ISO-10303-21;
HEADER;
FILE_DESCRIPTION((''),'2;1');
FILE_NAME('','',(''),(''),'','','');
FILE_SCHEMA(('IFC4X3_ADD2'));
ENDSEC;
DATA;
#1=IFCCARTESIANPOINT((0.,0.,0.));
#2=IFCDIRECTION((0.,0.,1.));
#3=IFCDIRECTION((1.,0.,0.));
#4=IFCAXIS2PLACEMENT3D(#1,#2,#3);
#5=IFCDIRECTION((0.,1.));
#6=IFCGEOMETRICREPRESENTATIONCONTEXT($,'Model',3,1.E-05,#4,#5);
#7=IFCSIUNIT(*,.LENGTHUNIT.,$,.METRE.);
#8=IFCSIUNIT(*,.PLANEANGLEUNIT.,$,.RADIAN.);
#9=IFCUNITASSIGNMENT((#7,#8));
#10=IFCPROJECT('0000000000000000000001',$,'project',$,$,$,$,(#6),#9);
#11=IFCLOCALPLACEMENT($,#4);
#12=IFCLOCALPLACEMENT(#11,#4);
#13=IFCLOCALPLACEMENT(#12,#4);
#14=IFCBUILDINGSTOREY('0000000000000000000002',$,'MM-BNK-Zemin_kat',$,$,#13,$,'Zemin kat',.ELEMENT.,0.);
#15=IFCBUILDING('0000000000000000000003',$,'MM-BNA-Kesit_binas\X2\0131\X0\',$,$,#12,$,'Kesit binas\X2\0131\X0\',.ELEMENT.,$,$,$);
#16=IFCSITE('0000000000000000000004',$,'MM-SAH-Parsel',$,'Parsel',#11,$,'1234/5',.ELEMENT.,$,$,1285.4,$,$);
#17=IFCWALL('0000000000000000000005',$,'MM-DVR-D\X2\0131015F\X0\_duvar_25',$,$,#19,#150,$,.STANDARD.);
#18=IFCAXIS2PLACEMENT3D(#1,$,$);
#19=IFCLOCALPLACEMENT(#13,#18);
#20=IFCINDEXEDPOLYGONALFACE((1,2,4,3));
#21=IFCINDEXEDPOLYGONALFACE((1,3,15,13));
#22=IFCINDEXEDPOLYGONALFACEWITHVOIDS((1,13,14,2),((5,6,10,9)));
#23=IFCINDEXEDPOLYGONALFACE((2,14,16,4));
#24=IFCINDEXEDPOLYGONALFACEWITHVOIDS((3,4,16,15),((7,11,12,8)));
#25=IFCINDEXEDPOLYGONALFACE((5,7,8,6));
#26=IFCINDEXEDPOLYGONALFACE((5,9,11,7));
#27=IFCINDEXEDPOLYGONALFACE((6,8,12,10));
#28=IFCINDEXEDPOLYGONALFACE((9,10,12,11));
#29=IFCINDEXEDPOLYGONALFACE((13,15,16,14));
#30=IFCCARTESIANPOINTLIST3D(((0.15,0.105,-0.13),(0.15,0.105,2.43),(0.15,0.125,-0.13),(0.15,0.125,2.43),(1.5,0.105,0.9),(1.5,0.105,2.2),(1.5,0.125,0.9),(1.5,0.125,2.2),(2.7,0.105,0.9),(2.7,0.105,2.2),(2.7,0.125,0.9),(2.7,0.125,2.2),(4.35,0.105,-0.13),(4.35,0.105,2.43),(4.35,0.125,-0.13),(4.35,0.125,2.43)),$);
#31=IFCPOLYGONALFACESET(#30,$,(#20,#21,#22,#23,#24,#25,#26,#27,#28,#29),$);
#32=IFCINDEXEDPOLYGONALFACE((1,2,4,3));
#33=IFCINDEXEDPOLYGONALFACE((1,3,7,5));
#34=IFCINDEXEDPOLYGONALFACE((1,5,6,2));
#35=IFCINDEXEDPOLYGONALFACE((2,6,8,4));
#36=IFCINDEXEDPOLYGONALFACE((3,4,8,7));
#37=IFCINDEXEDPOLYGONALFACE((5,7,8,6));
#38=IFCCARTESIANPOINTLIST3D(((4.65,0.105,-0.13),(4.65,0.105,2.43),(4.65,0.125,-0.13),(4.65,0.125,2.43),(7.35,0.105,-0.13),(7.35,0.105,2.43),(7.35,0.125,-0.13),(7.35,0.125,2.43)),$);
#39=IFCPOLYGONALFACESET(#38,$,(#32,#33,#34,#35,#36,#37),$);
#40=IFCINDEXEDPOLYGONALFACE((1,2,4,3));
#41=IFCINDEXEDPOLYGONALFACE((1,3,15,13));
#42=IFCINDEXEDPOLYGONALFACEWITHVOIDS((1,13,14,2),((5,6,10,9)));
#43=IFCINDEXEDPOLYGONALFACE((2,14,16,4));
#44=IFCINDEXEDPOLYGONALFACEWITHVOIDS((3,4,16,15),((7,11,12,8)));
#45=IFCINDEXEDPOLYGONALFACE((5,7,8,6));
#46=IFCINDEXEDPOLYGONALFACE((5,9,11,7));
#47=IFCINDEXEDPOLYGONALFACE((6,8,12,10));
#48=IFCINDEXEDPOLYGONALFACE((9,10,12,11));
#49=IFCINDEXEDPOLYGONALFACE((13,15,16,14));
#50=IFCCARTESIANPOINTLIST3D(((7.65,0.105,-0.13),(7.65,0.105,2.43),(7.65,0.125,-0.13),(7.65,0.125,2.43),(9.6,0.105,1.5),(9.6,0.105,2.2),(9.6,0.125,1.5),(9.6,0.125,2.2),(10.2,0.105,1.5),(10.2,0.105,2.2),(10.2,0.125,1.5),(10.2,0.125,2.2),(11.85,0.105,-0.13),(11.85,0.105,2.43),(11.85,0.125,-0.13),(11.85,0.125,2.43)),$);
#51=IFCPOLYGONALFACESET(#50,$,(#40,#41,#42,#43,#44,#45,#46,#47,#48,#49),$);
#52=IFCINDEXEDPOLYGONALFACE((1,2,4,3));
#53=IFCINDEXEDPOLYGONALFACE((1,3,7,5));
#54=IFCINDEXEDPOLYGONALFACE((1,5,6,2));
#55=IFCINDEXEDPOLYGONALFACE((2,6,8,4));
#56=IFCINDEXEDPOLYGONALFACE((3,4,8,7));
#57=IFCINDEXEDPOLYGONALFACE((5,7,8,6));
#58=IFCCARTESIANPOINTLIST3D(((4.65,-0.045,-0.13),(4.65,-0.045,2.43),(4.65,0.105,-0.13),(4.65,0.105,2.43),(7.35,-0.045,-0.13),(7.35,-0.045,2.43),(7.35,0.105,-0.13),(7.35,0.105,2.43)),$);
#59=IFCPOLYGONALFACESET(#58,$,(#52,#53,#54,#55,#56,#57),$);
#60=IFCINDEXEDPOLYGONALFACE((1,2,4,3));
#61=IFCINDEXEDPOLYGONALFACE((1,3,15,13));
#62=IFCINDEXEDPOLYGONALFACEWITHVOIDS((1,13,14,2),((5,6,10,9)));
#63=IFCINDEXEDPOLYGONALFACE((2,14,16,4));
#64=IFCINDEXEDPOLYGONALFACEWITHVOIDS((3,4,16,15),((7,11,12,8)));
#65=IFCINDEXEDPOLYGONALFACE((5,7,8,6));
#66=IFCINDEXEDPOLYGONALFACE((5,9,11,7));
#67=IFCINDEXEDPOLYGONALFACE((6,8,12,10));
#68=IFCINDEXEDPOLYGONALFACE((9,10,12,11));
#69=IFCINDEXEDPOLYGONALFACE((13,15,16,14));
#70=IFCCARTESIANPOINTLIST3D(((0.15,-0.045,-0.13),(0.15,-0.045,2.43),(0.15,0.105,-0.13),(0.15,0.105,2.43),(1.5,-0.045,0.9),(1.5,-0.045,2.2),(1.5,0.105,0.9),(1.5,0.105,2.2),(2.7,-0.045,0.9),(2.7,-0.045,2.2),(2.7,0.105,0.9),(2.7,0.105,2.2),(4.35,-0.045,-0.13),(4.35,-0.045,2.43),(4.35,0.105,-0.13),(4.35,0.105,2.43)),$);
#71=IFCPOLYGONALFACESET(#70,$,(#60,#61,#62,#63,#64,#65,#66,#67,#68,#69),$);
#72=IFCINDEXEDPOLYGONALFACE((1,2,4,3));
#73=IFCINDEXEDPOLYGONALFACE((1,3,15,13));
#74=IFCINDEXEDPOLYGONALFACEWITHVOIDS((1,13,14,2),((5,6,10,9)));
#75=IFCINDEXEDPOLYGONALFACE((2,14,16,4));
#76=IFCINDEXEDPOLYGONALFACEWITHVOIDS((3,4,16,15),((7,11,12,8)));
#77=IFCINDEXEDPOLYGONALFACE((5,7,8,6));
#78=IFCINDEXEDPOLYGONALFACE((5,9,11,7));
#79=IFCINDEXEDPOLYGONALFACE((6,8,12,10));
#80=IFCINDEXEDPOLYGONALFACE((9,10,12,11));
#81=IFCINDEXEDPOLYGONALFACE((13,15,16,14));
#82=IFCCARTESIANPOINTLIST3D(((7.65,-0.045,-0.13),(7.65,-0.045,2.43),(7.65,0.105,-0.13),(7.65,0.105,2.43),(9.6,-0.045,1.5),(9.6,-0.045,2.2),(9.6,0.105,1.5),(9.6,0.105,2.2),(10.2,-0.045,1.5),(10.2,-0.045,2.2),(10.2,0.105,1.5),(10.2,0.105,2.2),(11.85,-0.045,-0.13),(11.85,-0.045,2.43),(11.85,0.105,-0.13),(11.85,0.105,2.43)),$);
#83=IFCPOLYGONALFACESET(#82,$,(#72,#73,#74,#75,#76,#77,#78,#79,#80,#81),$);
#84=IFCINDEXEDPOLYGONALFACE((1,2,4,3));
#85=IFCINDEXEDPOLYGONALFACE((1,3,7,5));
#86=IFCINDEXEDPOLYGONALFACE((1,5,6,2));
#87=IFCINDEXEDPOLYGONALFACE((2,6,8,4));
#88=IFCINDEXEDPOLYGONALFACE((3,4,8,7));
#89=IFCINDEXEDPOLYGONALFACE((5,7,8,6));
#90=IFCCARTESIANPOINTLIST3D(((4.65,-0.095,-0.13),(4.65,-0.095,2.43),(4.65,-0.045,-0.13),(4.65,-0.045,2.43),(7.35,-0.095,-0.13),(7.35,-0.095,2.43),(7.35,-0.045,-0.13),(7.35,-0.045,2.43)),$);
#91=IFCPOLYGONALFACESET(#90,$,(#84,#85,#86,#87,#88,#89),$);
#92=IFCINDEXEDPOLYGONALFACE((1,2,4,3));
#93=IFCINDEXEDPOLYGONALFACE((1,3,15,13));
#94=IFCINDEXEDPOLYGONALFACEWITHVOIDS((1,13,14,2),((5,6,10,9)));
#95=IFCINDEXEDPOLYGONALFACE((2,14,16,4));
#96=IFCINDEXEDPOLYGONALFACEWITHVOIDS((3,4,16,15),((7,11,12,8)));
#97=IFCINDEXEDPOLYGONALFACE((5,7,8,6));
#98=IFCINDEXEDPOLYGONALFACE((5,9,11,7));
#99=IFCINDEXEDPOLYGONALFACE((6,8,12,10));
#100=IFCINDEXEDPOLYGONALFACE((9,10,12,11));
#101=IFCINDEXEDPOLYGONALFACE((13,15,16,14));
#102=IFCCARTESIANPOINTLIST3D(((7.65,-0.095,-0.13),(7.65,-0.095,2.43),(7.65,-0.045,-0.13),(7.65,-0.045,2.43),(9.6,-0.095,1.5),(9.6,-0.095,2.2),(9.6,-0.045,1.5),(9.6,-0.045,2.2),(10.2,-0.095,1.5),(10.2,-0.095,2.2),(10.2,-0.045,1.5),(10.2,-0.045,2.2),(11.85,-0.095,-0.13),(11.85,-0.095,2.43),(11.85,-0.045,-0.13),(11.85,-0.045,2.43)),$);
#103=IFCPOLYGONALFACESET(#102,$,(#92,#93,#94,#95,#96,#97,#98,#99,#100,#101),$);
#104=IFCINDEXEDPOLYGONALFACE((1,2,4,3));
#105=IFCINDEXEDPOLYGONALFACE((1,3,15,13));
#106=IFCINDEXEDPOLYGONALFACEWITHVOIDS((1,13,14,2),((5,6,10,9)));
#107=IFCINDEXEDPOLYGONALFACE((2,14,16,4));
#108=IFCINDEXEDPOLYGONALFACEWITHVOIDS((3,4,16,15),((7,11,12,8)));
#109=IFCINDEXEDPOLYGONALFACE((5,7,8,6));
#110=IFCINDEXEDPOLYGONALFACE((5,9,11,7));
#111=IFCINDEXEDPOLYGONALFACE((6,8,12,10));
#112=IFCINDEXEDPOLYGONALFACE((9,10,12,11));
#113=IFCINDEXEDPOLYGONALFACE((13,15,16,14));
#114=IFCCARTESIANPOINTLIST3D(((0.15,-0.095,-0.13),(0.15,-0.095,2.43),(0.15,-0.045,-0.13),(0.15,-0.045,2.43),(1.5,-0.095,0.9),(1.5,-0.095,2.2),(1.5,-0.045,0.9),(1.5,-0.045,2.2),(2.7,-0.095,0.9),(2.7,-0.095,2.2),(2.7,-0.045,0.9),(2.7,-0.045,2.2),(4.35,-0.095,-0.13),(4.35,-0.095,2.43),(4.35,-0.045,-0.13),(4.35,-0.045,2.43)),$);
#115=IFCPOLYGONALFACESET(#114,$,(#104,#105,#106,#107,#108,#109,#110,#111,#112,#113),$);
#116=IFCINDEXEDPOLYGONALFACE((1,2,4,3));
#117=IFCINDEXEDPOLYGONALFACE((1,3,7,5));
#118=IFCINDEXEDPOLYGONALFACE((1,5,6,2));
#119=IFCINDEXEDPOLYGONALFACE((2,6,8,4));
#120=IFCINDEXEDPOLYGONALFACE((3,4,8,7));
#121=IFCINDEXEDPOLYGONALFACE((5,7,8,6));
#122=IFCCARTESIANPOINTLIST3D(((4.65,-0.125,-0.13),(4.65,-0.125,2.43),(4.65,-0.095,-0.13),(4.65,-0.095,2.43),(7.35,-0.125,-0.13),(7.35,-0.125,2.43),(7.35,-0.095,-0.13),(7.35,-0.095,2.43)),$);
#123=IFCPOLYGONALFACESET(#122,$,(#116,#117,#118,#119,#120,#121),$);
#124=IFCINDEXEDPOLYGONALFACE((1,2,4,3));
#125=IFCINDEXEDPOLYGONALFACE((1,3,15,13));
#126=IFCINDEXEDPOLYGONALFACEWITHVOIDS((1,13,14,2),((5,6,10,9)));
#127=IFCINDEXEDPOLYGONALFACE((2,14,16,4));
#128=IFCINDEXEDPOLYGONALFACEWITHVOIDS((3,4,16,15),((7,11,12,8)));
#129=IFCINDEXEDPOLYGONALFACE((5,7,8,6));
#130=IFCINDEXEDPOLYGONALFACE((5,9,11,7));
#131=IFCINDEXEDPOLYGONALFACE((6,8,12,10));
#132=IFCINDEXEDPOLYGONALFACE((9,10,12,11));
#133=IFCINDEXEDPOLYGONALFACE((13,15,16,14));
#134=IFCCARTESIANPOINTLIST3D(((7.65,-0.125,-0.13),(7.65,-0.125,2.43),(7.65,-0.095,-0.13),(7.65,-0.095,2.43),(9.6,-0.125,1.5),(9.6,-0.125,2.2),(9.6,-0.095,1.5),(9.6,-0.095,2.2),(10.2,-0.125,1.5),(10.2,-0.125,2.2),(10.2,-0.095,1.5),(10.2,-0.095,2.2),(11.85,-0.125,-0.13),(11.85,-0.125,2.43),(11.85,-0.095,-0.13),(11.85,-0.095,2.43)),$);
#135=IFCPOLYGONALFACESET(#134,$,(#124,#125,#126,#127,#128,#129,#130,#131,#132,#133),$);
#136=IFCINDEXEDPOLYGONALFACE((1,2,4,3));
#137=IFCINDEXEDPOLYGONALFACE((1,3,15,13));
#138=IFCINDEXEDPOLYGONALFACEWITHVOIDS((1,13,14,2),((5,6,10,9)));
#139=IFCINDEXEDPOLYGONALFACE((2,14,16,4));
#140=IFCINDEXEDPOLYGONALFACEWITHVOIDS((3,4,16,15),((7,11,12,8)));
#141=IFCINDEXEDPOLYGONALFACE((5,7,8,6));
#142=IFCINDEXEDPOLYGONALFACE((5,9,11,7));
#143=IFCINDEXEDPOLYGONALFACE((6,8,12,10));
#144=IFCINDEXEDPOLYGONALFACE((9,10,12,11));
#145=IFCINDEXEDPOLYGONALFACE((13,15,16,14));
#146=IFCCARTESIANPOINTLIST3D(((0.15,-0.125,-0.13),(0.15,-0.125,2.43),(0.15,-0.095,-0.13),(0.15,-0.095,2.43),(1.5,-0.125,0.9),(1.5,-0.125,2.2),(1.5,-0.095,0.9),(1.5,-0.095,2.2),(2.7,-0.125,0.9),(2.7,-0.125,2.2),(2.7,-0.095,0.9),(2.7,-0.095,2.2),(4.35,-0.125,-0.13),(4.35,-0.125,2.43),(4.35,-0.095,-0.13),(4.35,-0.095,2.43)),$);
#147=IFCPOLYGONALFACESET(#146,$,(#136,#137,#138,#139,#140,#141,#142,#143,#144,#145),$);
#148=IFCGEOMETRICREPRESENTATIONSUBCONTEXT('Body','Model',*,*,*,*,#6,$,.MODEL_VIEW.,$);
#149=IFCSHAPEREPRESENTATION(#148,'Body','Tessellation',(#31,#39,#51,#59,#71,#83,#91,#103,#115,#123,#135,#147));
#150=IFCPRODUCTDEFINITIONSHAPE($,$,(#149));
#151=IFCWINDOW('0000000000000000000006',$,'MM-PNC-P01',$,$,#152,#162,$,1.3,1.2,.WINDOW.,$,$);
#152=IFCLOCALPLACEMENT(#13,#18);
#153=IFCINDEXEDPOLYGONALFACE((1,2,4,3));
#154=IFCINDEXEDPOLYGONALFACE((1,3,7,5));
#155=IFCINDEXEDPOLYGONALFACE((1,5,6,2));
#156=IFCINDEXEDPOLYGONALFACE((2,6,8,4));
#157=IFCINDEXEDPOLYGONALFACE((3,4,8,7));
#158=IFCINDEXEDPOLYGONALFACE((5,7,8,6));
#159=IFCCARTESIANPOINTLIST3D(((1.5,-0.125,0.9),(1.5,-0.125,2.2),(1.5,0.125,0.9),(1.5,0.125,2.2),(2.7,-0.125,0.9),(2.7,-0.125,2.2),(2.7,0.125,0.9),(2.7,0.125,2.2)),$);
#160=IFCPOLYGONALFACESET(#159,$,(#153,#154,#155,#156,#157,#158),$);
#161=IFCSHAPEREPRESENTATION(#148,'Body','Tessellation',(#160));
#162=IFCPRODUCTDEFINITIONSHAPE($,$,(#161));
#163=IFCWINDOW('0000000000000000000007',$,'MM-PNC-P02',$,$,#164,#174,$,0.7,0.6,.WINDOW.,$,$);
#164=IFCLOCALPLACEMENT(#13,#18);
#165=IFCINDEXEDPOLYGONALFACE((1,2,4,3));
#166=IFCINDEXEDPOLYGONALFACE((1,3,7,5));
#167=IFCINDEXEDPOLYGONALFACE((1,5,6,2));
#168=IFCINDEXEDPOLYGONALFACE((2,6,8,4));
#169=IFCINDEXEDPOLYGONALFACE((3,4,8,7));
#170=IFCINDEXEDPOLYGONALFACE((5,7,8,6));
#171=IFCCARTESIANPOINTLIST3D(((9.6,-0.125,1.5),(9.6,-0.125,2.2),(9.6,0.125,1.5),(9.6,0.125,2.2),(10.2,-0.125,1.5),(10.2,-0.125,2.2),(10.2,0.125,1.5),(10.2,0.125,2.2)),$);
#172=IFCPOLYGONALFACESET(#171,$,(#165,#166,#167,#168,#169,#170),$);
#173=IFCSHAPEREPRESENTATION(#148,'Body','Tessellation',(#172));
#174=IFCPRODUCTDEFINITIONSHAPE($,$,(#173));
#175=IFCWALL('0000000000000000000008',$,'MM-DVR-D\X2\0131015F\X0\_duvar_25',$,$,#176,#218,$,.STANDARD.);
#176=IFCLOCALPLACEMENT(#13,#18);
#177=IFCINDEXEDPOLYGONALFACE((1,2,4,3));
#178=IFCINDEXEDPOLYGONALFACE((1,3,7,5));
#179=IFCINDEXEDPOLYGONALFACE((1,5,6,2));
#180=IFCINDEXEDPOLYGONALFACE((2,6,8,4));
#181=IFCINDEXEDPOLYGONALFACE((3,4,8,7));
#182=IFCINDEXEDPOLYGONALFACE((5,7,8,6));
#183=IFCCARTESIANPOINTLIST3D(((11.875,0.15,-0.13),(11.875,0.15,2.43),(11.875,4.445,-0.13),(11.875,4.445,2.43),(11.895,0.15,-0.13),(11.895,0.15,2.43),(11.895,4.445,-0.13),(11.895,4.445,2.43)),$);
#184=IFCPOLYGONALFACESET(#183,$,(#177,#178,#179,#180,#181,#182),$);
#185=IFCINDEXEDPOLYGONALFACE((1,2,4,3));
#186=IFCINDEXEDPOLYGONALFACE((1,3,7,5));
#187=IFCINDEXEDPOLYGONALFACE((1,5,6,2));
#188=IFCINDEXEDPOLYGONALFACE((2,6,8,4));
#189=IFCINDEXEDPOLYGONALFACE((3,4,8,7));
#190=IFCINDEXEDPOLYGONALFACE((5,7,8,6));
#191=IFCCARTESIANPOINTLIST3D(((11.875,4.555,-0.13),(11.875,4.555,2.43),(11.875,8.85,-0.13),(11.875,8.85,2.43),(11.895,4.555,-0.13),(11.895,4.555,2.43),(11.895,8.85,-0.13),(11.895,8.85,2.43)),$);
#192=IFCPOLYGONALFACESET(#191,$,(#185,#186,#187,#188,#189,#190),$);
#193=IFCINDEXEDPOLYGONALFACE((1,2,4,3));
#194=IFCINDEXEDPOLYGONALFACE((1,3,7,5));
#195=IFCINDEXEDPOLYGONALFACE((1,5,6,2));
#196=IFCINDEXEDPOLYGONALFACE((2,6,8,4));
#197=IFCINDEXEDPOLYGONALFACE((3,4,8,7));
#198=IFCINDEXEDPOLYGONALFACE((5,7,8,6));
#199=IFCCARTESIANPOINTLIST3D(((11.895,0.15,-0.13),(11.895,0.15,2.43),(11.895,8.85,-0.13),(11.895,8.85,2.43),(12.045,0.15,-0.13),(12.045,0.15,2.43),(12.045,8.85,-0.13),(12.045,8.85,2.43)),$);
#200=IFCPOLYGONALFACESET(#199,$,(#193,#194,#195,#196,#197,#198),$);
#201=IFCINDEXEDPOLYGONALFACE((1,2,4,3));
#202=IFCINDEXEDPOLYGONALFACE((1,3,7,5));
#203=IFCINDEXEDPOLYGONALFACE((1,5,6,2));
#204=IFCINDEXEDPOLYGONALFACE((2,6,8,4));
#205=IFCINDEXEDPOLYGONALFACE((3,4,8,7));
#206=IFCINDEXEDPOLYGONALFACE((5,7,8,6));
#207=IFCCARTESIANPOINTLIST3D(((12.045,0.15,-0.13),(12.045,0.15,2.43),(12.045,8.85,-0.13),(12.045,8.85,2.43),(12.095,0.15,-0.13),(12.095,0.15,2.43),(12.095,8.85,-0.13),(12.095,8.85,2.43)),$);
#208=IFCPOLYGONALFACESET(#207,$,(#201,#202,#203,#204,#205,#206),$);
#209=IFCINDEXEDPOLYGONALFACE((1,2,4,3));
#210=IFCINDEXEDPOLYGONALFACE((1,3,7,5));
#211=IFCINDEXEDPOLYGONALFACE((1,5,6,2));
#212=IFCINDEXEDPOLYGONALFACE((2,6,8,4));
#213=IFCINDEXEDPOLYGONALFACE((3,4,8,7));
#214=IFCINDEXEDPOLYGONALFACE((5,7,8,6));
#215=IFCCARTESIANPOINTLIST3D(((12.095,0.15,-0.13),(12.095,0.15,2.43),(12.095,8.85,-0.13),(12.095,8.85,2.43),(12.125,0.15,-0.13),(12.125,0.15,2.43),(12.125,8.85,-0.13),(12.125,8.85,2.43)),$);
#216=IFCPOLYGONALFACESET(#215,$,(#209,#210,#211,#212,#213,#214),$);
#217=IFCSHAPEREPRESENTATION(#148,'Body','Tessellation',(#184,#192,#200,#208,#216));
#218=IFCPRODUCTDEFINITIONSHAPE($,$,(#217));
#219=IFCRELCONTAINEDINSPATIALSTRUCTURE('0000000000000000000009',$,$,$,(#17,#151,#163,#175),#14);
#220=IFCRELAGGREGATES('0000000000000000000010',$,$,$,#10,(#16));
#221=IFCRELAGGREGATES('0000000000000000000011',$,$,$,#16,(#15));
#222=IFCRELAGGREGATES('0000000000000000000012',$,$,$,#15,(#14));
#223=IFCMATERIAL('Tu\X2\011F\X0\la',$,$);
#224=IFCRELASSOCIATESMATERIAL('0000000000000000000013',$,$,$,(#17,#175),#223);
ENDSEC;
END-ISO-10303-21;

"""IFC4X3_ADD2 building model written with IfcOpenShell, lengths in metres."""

from ifc_helpers import new_model, si_unit, direction, frame, origin_with_axes, place, context, subcontext, project, spatial, polyline, outline, extrude, material, element, fill, save


model = new_model("IFC4X3_ADD2")

# Units and contexts
model_context = context("Model", 3, precision=1e-05, world=origin_with_axes(), true_north=direction((0.0, 1.0)))
body_context = subcontext(model_context, "Body", "Model", "MODEL_VIEW")
ifc_project = project(units=[si_unit("LENGTHUNIT", "METRE"), si_unit("PLANEANGLEUNIT", "RADIAN")], contexts=[model_context])

# Site, building, storey
site_placement = place(None, origin_with_axes())
site = spatial("IfcSite", under=ifc_project, at=site_placement, Name="MM-SAH-Parsel", ObjectType="Parsel", LongName="1234/5", CompositionType="ELEMENT", RefElevation=1285.4)
building_placement = place(site_placement, origin_with_axes())
building = spatial("IfcBuilding", under=site, at=building_placement, Name="MM-BNA-Kesit_binası", LongName="Kesit binası", CompositionType="ELEMENT")
storey_placement = place(building_placement, origin_with_axes())
storey = spatial("IfcBuildingStorey", under=building, at=storey_placement, Name="MM-BNK-Zemin_kat", LongName="Zemin kat", CompositionType="ELEMENT", Elevation=0.0)

# Wall, openings, windows
ifc_material_1 = material(Name="Tuğla")
wall_1_placement = place(storey_placement, origin_with_axes())
wall_1 = element("IfcWall", 1, at=wall_1_placement, inside=storey, material=ifc_material_1, Name="MM-DVR-Dış_duvar_25", PredefinedType="STANDARD", context=body_context, shape_type="SweptSolid", body=[
    extrude(outline(polyline([(0.15, 0.105), (4.35, 0.105), (4.35, 0.125), (0.15, 0.125), (0.15, 0.105)])), frame((0.0, 0.0, -0.13)), (0.0, 0.0, 1.0), 2.56),
    extrude(outline(polyline([(4.65, 0.105), (7.35, 0.105), (7.35, 0.125), (4.65, 0.125), (4.65, 0.105)])), frame((0.0, 0.0, -0.13)), (0.0, 0.0, 1.0), 2.56),
    extrude(outline(polyline([(7.65, 0.105), (11.85, 0.105), (11.85, 0.125), (7.65, 0.125), (7.65, 0.105)])), frame((0.0, 0.0, -0.13)), (0.0, 0.0, 1.0), 2.56),
    extrude(outline(polyline([(4.65, -0.045), (7.35, -0.045), (7.35, 0.105), (4.65, 0.105), (4.65, -0.045)])), frame((0.0, 0.0, -0.13)), (0.0, 0.0, 1.0), 2.56),
    extrude(outline(polyline([(0.15, -0.045), (4.35, -0.045), (4.35, 0.105), (0.15, 0.105), (0.15, -0.045)])), frame((0.0, 0.0, -0.13)), (0.0, 0.0, 1.0), 2.56),
    extrude(outline(polyline([(7.65, -0.045), (11.85, -0.045), (11.85, 0.105), (7.65, 0.105), (7.65, -0.045)])), frame((0.0, 0.0, -0.13)), (0.0, 0.0, 1.0), 2.56),
    extrude(outline(polyline([(4.65, -0.095), (7.35, -0.095), (7.35, -0.045), (4.65, -0.045), (4.65, -0.095)])), frame((0.0, 0.0, -0.13)), (0.0, 0.0, 1.0), 2.56),
    extrude(outline(polyline([(7.65, -0.095), (11.85, -0.095), (11.85, -0.045), (7.65, -0.045), (7.65, -0.095)])), frame((0.0, 0.0, -0.13)), (0.0, 0.0, 1.0), 2.56),
    extrude(outline(polyline([(0.15, -0.095), (4.35, -0.095), (4.35, -0.045), (0.15, -0.045), (0.15, -0.095)])), frame((0.0, 0.0, -0.13)), (0.0, 0.0, 1.0), 2.56),
    extrude(outline(polyline([(4.65, -0.125), (7.35, -0.125), (7.35, -0.095), (4.65, -0.095), (4.65, -0.125)])), frame((0.0, 0.0, -0.13)), (0.0, 0.0, 1.0), 2.56),
    extrude(outline(polyline([(7.65, -0.125), (11.85, -0.125), (11.85, -0.095), (7.65, -0.095), (7.65, -0.125)])), frame((0.0, 0.0, -0.13)), (0.0, 0.0, 1.0), 2.56),
    extrude(outline(polyline([(0.15, -0.125), (4.35, -0.125), (4.35, -0.095), (0.15, -0.095), (0.15, -0.125)])), frame((0.0, 0.0, -0.13)), (0.0, 0.0, 1.0), 2.56),
])
opening_1_placement = place(storey_placement, origin_with_axes())
opening_1 = element("IfcOpeningElement", 2, at=opening_1_placement, cuts=wall_1, PredefinedType="OPENING", context=body_context, shape_type="SweptSolid", body=[
    extrude(outline(polyline([(1.5, 0.125), (2.7, 0.125), (2.7, -0.125), (1.5, -0.125), (1.5, 0.125)])), frame((0.0, 0.0, 0.9)), (0.0, 0.0, 1.0), 1.3),
])
opening_2_placement = place(storey_placement, origin_with_axes())
opening_2 = element("IfcOpeningElement", 3, at=opening_2_placement, cuts=wall_1, PredefinedType="OPENING", context=body_context, shape_type="SweptSolid", body=[
    extrude(outline(polyline([(9.6, 0.125), (10.2, 0.125), (10.2, -0.125), (9.6, -0.125), (9.6, 0.125)])), frame((0.0, 0.0, 1.5)), (0.0, 0.0, 1.0), 0.7),
])
window_1_placement = place(storey_placement, origin_with_axes())
window_1 = element("IfcWindow", 4, at=window_1_placement, inside=storey, Name="MM-PNC-P01", OverallHeight=1.3, OverallWidth=1.2, PredefinedType="WINDOW", context=body_context, shape_type="SweptSolid", body=[
    extrude(outline(polyline([(1.5, 0.125), (2.7, 0.125), (2.7, -0.125), (1.5, -0.125), (1.5, 0.125)])), frame((0.0, 0.0, 0.9)), (0.0, 0.0, 1.0), 1.3),
])
fill(opening_1, window_1)
window_2_placement = place(storey_placement, origin_with_axes())
window_2 = element("IfcWindow", 5, at=window_2_placement, inside=storey, Name="MM-PNC-P02", OverallHeight=0.7, OverallWidth=0.6, PredefinedType="WINDOW", context=body_context, shape_type="SweptSolid", body=[
    extrude(outline(polyline([(9.6, 0.125), (10.2, 0.125), (10.2, -0.125), (9.6, -0.125), (9.6, 0.125)])), frame((0.0, 0.0, 1.5)), (0.0, 0.0, 1.0), 0.7),
])
fill(opening_2, window_2)

# Wall
wall_2_placement = place(storey_placement, origin_with_axes())
element("IfcWall", 6, at=wall_2_placement, inside=storey, material=ifc_material_1, Name="MM-DVR-Dış_duvar_25", PredefinedType="STANDARD", context=body_context, shape_type="SweptSolid", body=[
    extrude(outline(polyline([(11.895, 0.15), (11.895, 4.445), (11.875, 4.445), (11.875, 0.15), (11.895, 0.15)])), frame((0.0, 0.0, -0.13)), (0.0, 0.0, 1.0), 2.56),
    extrude(outline(polyline([(11.895, 4.555), (11.895, 8.85), (11.875, 8.85), (11.875, 4.555), (11.895, 4.555)])), frame((0.0, 0.0, -0.13)), (0.0, 0.0, 1.0), 2.56),
    extrude(outline(polyline([(12.045, 0.15), (12.045, 8.85), (11.895, 8.85), (11.895, 0.15), (12.045, 0.15)])), frame((0.0, 0.0, -0.13)), (0.0, 0.0, 1.0), 2.56),
    extrude(outline(polyline([(12.095, 0.15), (12.095, 8.85), (12.045, 8.85), (12.045, 0.15), (12.095, 0.15)])), frame((0.0, 0.0, -0.13)), (0.0, 0.0, 1.0), 2.56),
    extrude(outline(polyline([(12.125, 0.15), (12.125, 8.85), (12.095, 8.85), (12.095, 0.15), (12.125, 0.15)])), frame((0.0, 0.0, -0.13)), (0.0, 0.0, 1.0), 2.56),
])

save(model, "model.ifc")
